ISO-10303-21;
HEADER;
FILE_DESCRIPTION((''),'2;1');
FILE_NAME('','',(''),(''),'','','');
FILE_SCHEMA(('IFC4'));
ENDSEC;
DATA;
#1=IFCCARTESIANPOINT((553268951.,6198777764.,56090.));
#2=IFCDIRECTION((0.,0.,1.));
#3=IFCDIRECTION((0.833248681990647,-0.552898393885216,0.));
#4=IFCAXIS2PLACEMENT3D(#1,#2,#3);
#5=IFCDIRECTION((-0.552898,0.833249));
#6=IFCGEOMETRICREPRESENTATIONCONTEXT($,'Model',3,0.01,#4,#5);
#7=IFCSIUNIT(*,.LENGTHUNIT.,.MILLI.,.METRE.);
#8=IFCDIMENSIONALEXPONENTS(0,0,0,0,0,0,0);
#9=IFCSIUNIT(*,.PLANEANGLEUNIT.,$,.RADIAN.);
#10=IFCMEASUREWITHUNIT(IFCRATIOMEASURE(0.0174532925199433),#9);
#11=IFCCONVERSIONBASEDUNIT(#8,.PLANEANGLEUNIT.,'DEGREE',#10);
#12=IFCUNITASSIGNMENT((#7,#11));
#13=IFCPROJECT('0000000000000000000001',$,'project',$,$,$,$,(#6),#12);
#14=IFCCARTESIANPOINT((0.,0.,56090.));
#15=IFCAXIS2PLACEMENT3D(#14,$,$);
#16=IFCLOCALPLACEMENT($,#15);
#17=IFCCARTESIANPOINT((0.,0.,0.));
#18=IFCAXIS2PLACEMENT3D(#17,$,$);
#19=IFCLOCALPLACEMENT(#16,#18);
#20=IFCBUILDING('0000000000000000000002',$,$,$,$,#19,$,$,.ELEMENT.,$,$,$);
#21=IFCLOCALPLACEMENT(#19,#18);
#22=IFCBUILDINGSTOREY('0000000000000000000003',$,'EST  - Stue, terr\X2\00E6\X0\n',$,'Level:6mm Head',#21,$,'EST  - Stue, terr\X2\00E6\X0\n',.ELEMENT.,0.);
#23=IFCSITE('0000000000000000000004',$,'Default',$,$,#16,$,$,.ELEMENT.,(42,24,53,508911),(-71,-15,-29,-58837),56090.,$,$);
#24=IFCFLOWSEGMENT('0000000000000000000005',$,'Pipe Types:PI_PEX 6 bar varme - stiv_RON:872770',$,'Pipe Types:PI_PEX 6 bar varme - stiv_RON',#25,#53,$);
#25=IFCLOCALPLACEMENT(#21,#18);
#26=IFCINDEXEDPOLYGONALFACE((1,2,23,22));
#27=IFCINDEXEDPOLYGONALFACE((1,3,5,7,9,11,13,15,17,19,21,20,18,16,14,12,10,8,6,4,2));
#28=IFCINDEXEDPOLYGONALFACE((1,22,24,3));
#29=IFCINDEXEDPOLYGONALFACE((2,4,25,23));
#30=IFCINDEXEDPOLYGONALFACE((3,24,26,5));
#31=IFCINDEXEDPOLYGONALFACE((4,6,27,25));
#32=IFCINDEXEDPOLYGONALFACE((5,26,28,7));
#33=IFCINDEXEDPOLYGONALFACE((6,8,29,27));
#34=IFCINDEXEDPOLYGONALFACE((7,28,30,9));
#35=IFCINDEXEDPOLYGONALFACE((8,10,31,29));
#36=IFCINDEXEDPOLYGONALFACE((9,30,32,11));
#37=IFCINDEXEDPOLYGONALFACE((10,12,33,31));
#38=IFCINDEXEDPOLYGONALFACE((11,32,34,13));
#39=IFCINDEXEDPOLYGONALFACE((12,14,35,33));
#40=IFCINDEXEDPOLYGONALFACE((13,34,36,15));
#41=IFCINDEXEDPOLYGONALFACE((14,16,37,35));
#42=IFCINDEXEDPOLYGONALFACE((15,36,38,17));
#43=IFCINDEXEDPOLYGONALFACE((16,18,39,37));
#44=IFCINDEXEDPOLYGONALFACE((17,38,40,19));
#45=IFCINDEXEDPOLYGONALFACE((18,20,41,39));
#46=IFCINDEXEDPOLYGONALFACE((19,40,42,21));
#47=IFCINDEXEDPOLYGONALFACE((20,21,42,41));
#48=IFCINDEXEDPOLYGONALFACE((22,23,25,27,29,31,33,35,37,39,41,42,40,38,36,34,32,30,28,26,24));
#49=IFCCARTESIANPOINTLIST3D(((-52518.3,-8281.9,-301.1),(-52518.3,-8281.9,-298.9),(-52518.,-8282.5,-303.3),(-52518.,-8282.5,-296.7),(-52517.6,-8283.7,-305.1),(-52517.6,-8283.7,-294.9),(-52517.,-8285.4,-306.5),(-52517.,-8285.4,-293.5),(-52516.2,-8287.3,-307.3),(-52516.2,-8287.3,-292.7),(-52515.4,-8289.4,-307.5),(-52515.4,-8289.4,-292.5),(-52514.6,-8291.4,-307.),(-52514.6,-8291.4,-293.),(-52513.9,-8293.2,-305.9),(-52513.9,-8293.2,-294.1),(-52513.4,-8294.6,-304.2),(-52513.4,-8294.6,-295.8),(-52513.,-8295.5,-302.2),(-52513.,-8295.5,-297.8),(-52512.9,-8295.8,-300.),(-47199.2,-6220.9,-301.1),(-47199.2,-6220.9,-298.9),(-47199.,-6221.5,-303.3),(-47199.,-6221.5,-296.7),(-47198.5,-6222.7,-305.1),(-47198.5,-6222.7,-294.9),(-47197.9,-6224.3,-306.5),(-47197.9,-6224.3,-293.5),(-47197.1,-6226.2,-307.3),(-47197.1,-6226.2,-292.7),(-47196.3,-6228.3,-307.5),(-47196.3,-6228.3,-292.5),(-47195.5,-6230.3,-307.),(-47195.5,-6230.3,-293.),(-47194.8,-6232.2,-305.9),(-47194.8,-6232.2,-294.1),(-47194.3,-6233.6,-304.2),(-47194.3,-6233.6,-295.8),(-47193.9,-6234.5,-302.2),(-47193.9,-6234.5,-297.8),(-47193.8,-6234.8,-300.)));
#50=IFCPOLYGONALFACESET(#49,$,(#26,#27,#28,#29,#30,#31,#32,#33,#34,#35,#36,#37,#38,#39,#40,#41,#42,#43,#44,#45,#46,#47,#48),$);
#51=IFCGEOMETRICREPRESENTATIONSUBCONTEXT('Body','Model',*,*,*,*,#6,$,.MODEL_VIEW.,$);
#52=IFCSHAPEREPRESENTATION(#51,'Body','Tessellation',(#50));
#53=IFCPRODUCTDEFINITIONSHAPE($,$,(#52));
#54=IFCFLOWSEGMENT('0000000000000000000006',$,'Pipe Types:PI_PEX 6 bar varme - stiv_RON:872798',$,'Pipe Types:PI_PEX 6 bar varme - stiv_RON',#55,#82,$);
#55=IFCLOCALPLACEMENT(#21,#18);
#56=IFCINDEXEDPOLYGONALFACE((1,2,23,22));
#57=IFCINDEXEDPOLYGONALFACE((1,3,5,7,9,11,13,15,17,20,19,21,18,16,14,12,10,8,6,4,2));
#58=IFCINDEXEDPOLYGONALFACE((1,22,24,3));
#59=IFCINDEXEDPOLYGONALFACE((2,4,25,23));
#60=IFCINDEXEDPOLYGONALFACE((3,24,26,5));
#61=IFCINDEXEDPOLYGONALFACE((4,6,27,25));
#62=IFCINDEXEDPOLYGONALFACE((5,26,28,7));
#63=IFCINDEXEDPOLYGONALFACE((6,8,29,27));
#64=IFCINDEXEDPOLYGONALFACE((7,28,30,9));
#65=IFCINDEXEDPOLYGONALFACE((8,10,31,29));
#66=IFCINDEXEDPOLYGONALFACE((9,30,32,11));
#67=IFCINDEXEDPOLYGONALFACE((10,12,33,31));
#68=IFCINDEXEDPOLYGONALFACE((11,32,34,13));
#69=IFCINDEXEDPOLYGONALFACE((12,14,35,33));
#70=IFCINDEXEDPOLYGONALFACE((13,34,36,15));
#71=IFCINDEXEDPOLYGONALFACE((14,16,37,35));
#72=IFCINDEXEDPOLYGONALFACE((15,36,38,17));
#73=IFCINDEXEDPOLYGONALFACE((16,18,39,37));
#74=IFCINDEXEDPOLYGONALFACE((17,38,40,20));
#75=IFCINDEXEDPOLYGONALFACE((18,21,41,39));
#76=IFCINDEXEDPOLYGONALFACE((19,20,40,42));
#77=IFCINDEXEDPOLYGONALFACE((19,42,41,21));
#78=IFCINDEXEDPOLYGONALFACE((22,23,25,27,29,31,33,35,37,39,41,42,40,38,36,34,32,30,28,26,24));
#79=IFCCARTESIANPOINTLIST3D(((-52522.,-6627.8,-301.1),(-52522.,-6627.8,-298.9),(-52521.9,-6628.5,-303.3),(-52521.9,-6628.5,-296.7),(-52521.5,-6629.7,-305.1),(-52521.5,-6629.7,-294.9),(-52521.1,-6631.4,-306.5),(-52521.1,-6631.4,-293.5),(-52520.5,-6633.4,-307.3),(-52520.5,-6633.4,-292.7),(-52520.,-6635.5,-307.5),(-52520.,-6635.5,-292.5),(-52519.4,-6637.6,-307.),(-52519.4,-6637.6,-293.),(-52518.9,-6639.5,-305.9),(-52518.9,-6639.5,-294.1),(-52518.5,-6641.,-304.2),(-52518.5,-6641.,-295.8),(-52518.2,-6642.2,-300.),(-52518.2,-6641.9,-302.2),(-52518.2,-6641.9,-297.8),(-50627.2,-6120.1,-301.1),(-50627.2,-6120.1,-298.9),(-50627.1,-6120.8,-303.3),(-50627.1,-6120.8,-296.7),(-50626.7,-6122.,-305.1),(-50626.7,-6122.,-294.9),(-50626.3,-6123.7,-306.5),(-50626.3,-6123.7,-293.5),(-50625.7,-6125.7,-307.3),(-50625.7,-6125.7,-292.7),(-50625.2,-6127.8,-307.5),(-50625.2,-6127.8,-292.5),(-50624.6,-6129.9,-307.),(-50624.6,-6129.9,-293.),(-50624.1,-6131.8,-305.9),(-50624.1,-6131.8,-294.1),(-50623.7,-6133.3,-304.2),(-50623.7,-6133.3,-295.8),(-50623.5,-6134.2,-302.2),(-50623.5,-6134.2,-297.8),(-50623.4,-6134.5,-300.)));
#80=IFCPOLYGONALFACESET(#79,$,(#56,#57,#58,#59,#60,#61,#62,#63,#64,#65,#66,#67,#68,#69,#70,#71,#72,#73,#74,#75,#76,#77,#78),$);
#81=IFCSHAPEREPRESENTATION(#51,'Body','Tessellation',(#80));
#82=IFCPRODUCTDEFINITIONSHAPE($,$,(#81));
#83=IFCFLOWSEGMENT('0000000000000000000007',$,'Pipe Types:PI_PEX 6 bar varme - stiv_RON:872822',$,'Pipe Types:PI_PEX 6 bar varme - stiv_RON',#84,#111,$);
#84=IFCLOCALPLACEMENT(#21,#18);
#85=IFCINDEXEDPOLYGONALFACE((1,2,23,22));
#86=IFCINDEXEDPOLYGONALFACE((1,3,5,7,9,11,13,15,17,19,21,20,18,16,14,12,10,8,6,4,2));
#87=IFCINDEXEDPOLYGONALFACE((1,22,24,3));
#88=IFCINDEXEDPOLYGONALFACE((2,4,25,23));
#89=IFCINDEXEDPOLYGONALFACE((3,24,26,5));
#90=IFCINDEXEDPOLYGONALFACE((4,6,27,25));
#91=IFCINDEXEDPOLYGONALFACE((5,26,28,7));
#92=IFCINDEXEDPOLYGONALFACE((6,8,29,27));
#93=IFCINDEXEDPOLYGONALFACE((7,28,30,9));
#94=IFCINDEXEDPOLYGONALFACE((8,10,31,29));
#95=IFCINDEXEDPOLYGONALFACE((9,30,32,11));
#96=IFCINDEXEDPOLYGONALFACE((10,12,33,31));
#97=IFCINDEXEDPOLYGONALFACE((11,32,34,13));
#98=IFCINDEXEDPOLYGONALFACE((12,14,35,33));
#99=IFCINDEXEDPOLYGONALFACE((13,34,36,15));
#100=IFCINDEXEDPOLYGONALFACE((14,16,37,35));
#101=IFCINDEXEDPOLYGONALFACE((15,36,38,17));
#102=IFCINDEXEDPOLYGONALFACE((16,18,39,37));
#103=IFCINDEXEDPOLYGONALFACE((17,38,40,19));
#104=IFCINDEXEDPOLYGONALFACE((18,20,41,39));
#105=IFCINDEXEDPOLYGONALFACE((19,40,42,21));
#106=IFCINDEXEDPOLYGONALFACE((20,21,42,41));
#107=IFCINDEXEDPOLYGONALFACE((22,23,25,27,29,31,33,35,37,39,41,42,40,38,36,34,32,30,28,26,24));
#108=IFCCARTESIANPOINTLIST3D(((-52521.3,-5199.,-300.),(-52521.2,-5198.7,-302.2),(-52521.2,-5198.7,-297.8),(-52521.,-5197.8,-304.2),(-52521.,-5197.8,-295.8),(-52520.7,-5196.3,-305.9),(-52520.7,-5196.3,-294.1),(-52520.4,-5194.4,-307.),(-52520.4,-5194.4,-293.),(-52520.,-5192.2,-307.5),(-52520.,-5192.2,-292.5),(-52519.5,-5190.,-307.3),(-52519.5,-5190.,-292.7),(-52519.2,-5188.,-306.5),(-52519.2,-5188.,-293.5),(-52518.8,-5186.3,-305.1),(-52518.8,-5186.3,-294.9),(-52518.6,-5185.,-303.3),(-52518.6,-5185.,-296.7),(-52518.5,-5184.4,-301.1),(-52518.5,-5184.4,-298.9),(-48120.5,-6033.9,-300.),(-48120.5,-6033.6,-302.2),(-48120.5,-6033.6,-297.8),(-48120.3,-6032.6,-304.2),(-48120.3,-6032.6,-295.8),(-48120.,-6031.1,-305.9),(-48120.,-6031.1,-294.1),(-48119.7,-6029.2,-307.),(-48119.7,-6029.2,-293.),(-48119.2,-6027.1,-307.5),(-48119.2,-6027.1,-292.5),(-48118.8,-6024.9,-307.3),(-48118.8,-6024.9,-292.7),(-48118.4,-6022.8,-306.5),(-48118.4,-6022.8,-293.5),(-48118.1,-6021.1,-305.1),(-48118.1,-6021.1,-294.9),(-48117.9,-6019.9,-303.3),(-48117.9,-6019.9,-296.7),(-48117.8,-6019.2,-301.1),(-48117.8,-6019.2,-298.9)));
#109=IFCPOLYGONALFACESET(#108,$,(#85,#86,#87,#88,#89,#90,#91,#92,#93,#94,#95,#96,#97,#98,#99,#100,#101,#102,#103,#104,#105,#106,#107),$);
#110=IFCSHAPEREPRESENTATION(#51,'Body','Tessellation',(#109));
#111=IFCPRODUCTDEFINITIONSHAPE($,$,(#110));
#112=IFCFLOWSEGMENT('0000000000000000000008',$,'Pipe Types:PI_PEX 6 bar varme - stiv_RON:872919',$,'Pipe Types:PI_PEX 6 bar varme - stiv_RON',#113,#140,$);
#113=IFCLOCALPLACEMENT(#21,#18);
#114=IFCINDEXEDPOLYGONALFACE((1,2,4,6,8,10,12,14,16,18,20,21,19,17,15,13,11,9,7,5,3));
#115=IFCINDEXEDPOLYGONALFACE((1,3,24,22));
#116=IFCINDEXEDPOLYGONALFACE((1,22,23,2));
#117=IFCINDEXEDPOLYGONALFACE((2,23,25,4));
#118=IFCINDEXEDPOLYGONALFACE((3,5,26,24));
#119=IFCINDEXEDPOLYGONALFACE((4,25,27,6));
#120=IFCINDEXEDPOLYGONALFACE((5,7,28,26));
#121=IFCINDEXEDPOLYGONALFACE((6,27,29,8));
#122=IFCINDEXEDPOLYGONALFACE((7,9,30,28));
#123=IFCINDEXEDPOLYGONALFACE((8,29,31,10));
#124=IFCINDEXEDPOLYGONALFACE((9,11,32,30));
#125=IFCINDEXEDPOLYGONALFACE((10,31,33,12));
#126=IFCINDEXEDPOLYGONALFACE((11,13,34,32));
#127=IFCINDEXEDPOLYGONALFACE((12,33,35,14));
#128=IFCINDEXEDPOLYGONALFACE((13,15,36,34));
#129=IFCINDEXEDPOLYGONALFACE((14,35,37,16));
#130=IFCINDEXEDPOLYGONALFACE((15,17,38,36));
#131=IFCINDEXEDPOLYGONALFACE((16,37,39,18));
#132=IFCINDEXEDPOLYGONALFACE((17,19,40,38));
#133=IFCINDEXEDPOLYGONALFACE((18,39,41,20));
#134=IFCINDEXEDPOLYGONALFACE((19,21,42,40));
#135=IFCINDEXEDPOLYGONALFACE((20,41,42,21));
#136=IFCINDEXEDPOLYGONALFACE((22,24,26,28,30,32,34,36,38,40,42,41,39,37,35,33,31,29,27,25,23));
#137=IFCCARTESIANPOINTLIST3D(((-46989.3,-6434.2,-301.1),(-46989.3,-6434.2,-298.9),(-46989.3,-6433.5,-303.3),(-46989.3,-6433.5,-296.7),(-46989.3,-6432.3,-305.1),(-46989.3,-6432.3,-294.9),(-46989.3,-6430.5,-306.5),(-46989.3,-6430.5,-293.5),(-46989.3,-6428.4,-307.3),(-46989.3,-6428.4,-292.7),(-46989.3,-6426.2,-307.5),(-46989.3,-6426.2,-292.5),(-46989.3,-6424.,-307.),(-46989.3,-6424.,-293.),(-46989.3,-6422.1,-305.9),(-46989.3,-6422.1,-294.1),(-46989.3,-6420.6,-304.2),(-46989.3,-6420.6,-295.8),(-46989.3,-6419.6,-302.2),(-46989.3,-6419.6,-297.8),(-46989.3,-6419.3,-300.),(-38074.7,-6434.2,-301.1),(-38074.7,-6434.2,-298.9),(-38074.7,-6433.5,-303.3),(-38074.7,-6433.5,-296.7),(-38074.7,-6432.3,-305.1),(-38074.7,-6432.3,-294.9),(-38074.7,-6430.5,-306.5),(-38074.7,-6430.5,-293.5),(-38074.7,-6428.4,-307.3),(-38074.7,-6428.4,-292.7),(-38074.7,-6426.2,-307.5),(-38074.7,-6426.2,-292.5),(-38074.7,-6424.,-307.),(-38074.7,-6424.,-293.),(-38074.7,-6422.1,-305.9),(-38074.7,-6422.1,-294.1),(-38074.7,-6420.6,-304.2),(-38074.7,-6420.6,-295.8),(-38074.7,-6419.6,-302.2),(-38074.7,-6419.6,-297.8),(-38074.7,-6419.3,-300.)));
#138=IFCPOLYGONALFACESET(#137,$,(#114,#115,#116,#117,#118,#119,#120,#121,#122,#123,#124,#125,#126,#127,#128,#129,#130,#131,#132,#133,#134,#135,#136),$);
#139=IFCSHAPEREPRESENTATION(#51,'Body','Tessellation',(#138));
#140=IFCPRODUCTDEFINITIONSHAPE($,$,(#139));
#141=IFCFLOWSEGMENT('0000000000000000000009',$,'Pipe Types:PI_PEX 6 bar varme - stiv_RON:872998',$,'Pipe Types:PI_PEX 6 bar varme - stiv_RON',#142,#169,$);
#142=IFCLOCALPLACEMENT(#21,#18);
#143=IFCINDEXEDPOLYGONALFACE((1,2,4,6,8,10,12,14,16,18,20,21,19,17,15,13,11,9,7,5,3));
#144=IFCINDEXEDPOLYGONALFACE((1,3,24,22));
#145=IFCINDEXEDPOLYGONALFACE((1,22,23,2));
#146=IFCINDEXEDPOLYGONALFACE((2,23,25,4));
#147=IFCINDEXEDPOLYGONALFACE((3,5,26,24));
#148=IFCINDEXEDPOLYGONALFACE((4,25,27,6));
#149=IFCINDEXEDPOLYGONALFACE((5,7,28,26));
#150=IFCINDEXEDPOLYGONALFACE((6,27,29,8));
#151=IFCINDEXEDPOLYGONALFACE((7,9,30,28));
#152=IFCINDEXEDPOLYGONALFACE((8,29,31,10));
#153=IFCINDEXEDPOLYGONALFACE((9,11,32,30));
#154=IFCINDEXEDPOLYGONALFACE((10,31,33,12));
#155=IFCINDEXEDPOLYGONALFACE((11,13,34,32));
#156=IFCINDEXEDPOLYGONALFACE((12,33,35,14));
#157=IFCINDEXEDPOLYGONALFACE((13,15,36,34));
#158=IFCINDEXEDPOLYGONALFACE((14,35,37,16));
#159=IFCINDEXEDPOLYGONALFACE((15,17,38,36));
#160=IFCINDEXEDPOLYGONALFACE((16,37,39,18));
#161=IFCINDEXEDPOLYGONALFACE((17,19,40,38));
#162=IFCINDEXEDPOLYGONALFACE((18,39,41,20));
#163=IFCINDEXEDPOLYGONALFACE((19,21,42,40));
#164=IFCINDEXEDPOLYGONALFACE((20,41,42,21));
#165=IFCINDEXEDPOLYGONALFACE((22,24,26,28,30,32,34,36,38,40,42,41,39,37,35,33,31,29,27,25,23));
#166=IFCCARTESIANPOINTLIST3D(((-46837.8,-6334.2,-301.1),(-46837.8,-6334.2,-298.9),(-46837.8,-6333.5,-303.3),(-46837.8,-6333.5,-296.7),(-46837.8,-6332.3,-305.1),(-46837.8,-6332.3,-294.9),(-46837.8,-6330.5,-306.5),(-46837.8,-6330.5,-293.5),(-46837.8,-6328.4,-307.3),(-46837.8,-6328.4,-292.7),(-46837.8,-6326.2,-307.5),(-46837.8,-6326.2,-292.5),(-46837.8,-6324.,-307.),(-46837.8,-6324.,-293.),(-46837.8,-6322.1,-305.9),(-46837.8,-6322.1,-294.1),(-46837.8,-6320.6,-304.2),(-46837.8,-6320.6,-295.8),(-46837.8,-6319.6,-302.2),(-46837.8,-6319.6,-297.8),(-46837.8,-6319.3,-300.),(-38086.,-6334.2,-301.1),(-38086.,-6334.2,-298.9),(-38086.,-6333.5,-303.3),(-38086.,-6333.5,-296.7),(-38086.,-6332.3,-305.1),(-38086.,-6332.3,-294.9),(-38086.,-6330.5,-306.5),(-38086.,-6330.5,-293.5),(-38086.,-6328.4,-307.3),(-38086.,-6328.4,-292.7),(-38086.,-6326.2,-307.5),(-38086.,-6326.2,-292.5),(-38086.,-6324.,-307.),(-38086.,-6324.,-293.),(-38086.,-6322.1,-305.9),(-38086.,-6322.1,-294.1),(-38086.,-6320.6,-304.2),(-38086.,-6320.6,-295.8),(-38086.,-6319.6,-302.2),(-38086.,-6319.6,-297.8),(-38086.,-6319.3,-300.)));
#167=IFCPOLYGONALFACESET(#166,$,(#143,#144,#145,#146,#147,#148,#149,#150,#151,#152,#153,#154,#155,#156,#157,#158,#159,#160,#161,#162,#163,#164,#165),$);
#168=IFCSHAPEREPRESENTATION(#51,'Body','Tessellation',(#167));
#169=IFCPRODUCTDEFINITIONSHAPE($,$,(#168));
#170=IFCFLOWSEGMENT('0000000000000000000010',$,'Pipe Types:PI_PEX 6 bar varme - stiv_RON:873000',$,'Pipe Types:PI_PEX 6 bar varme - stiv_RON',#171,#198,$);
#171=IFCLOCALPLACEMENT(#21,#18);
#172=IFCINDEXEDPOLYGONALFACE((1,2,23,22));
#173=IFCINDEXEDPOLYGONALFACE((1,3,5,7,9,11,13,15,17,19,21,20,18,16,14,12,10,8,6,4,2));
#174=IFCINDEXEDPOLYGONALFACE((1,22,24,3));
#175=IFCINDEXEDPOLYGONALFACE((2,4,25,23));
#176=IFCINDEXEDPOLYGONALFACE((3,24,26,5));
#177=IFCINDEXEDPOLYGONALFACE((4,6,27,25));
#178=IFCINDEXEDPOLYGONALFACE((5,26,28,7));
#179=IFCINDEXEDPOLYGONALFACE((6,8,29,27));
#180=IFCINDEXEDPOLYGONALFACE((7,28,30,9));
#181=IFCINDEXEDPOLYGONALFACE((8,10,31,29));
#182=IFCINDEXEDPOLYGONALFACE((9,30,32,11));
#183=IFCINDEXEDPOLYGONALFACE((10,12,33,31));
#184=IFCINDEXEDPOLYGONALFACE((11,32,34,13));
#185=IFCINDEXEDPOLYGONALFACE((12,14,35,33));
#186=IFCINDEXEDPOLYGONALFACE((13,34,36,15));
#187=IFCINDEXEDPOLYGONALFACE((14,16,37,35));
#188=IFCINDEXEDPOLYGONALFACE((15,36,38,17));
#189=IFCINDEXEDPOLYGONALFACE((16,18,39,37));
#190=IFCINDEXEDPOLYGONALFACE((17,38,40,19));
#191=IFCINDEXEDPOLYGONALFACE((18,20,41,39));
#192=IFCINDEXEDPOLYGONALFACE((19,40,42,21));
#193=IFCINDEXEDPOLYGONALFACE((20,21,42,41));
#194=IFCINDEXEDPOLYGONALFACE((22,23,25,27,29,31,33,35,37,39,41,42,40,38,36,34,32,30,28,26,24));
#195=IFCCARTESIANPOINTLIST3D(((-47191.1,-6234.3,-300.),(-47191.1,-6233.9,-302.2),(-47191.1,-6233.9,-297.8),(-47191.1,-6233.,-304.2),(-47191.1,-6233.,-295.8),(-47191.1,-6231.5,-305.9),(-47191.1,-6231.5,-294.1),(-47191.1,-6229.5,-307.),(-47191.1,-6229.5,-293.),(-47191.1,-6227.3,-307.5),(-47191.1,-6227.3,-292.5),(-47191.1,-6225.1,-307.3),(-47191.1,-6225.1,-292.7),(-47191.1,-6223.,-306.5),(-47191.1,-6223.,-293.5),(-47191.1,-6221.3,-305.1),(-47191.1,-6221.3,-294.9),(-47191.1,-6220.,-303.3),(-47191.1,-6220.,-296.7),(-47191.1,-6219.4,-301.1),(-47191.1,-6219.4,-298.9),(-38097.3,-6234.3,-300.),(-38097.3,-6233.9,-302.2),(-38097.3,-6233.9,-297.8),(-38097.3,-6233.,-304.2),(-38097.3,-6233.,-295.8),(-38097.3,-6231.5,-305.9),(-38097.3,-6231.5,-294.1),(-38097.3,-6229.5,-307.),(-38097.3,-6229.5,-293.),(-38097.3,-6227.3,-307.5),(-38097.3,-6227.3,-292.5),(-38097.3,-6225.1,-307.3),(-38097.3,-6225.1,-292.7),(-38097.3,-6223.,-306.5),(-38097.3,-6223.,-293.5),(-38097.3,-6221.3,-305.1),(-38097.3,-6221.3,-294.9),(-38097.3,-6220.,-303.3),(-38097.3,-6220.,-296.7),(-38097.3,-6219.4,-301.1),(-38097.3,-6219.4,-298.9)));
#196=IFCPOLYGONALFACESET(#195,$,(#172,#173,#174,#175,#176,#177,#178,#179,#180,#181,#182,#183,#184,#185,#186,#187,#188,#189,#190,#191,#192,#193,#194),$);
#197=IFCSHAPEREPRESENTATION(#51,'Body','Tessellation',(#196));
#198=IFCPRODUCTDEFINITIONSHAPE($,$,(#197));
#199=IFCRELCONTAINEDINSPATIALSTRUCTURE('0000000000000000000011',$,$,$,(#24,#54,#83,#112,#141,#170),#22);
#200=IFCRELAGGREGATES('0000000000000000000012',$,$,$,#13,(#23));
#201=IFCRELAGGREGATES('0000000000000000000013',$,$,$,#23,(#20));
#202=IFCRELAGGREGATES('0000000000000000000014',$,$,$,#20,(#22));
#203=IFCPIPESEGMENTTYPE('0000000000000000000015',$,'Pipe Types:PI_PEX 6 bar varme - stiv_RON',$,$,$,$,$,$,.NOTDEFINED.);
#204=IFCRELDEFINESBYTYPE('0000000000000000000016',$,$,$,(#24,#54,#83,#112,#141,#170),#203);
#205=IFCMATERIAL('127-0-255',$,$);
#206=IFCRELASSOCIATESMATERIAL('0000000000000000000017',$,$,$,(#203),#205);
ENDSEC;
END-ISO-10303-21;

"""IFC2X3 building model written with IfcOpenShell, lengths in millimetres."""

from ifc_helpers import new_model, entity, si_unit, converted_unit, direction, frame, frame_2d, origin, origin_2d_with_axis, place, context, subcontext, project, spatial, circle, extrude, material, type_object, element, save


model = new_model("IFC2X3")

# Units and contexts
model_context = context("Model", 3, precision=0.01, world=frame((553268951.0, 6198777764.0, 56090.0), z_axis=(0.0, 0.0, 1.0), x_axis=(0.833248681990647, -0.552898393885216, 0.0)), true_north=direction((-0.552898, 0.833249)))
body_context = subcontext(model_context, "Body", "Model", "MODEL_VIEW")
ifc_project = project(units=[si_unit("LENGTHUNIT", "METRE", prefix="MILLI"), converted_unit("PLANEANGLEUNIT", "DEGREE", entity("IfcRatioMeasure", 0.0174532925199433), si_unit("PLANEANGLEUNIT", "RADIAN"), dimensions=[0, 0, 0, 0, 0, 0, 0])], contexts=[model_context])

# Site, building, storey
site_placement = place(None, frame((0.0, 0.0, 56090.0)))
site = spatial("IfcSite", under=ifc_project, at=site_placement, Name="Default", CompositionType="ELEMENT", RefLatitude=(42, 24, 53, 508911), RefLongitude=(-71, -15, -29, -58837), RefElevation=56090.0)
building_placement = place(site_placement, origin())
building = spatial("IfcBuilding", under=site, at=building_placement, CompositionType="ELEMENT")
storey_placement = place(building_placement, frame((0.0, 0.0, 0.0)))
storey = spatial("IfcBuildingStorey", under=building, at=storey_placement, Name="EST  - Stue, terræn", ObjectType="Level:6mm Head", LongName="EST  - Stue, terræn", CompositionType="ELEMENT", Elevation=0.0)

# Flow segments
ifc_material_1 = material(Name="127-0-255")
pipe_segment_type_1 = type_object("IfcPipeSegmentType", Name="Pipe Types:PI_PEX 6 bar varme - stiv_RON", PredefinedType="NOTDEFINED", material=ifc_material_1)
flow_segment_1_placement = place(storey_placement, origin())
element("IfcFlowSegment", 1, at=flow_segment_1_placement, inside=storey, type_object=pipe_segment_type_1, Name="Pipe Types:PI_PEX 6 bar varme - stiv_RON:872770", ObjectType="Pipe Types:PI_PEX 6 bar varme - stiv_RON", context=body_context, shape_type="SweptSolid", body=[
    extrude(circle(Radius=7.5, at=origin_2d_with_axis()), frame((-52515.6, -8288.8, -300.0), z_axis=(0.932447, 0.361307, 0.0), x_axis=(0.361307, -0.932447, 0.0)), (0.0, 0.0, 1.0), 5704.4),
])
flow_segment_2_placement = place(storey_placement, origin())
element("IfcFlowSegment", 2, at=flow_segment_2_placement, inside=storey, type_object=pipe_segment_type_1, Name="Pipe Types:PI_PEX 6 bar varme - stiv_RON:872798", ObjectType="Pipe Types:PI_PEX 6 bar varme - stiv_RON", context=body_context, shape_type="SweptSolid", body=[
    extrude(circle(Radius=7.5, at=origin_2d_with_axis()), frame((-52520.1, -6635.0, -300.0), z_axis=(0.965926, 0.258819, 0.0), x_axis=(0.258819, -0.965926, 0.0)), (0.0, 0.0, 1.0), 1961.6),
])
flow_segment_3_placement = place(storey_placement, origin())
element("IfcFlowSegment", 3, at=flow_segment_3_placement, inside=storey, type_object=pipe_segment_type_1, Name="Pipe Types:PI_PEX 6 bar varme - stiv_RON:872822", ObjectType="Pipe Types:PI_PEX 6 bar varme - stiv_RON", context=body_context, shape_type="SweptSolid", body=[
    extrude(circle(Radius=7.5, at=frame_2d((0.0, 0.0), x_axis=(1.0, 0.0))), frame((-48119.1, -6026.5, -300.0), z_axis=(-0.982477, 0.186381, 0.0), x_axis=(-0.186381, -0.982477, 0.0)), (0.0, 0.0, 1.0), 4479.2),
])
flow_segment_4_placement = place(storey_placement, origin())
element("IfcFlowSegment", 4, at=flow_segment_4_placement, inside=storey, type_object=pipe_segment_type_1, Name="Pipe Types:PI_PEX 6 bar varme - stiv_RON:872919", ObjectType="Pipe Types:PI_PEX 6 bar varme - stiv_RON", context=body_context, shape_type="SweptSolid", body=[
    extrude(circle(Radius=7.5, at=frame_2d((0.0, 0.0), x_axis=(1.0, 0.0))), frame((-46989.3, -6426.8, -300.0), z_axis=(1.0, 0.0, 0.0), x_axis=(0.0, 1.0, 0.0)), (0.0, 0.0, 1.0), 8914.7),
])
flow_segment_5_placement = place(storey_placement, origin())
element("IfcFlowSegment", 5, at=flow_segment_5_placement, inside=storey, type_object=pipe_segment_type_1, Name="Pipe Types:PI_PEX 6 bar varme - stiv_RON:872998", ObjectType="Pipe Types:PI_PEX 6 bar varme - stiv_RON", context=body_context, shape_type="SweptSolid", body=[
    extrude(circle(Radius=7.5, at=frame_2d((0.0, 0.0), x_axis=(1.0, 0.0))), frame((-46837.8, -6326.8, -300.0), z_axis=(1.0, 0.0, 0.0), x_axis=(0.0, 1.0, 0.0)), (0.0, 0.0, 1.0), 8751.8),
])
flow_segment_6_placement = place(storey_placement, origin())
element("IfcFlowSegment", 6, at=flow_segment_6_placement, inside=storey, type_object=pipe_segment_type_1, Name="Pipe Types:PI_PEX 6 bar varme - stiv_RON:873000", ObjectType="Pipe Types:PI_PEX 6 bar varme - stiv_RON", context=body_context, shape_type="SweptSolid", body=[
    extrude(circle(Radius=7.5, at=origin_2d_with_axis()), frame((-47191.1, -6226.8, -300.0), z_axis=(1.0, 0.0, 0.0), x_axis=(0.0, -1.0, 0.0)), (0.0, 0.0, 1.0), 9093.8),
])

save(model, "model.ifc")
